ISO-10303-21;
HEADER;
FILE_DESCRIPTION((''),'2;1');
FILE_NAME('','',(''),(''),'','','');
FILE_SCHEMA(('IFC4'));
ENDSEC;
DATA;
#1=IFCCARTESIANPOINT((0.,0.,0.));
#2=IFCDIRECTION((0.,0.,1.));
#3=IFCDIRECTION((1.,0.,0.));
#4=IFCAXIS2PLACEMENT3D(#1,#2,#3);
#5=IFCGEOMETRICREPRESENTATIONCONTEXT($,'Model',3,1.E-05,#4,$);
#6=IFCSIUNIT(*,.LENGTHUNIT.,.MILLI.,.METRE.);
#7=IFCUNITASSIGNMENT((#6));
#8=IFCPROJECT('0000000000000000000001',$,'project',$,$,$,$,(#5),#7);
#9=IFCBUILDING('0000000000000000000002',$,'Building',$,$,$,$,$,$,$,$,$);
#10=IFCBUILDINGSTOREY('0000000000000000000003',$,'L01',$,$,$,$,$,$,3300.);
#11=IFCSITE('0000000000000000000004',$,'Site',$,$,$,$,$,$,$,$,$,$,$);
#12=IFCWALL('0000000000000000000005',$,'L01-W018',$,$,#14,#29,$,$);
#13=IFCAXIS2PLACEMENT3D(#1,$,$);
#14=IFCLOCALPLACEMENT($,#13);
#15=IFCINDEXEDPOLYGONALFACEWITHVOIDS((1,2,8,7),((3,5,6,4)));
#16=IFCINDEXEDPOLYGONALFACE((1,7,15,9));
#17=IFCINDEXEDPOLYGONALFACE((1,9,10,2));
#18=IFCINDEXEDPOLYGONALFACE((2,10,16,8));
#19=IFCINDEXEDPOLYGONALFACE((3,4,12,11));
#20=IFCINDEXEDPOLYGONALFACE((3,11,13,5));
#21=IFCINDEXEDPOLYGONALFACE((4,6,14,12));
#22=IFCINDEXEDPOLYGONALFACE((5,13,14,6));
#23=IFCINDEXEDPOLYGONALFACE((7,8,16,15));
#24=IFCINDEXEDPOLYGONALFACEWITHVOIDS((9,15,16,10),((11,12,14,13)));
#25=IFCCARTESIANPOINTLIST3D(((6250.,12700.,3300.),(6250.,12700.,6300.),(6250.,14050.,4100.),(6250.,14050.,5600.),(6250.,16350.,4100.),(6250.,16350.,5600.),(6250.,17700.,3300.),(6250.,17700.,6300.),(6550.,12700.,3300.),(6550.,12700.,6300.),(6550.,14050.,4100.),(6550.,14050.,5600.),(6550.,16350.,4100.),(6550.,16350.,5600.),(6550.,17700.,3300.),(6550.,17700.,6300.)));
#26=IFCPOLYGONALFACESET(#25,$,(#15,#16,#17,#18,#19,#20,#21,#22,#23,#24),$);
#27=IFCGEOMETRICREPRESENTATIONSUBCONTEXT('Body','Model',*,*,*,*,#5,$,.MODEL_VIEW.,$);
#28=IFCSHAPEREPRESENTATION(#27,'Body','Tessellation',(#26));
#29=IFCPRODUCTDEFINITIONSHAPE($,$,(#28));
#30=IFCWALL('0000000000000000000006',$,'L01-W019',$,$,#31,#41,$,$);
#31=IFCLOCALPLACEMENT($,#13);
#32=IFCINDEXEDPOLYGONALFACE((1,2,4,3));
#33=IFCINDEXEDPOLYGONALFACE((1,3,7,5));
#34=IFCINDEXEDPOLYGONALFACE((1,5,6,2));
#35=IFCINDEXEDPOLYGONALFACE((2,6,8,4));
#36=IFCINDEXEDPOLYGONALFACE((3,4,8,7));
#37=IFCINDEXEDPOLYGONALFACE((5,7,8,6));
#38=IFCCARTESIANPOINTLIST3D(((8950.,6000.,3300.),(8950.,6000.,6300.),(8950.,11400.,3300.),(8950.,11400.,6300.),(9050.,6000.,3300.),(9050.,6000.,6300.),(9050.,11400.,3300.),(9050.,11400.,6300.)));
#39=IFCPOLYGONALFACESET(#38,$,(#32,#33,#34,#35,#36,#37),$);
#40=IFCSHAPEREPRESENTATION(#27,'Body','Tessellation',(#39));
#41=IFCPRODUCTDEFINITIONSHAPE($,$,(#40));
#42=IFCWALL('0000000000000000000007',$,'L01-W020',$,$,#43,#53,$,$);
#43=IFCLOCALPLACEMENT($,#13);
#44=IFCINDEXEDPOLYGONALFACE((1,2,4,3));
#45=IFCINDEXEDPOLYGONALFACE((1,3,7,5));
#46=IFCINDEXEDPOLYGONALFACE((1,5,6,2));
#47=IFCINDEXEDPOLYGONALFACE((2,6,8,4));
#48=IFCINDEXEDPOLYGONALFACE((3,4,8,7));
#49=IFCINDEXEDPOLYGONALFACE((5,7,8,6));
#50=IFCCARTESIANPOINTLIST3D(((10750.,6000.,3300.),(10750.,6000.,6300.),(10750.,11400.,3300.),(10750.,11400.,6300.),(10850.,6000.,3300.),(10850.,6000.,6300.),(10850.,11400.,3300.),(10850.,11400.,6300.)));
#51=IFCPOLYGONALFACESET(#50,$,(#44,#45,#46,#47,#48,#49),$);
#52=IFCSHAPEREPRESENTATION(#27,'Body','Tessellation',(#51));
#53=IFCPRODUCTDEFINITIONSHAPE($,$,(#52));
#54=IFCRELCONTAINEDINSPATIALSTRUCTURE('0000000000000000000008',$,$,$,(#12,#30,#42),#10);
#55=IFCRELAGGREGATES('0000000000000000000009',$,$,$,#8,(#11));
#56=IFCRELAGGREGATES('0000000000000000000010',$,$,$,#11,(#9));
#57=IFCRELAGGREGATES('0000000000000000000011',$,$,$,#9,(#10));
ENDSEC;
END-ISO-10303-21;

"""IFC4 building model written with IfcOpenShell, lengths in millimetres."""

from ifc_helpers import new_model, si_unit, frame, origin_with_axes, place, context, subcontext, project, spatial, indexed_curve, outline, extrude, element, save


model = new_model("IFC4")

# Units and contexts
model_context = context("Model", 3, precision=1e-05, world=origin_with_axes())
body_context = subcontext(model_context, "Body", "Model", "MODEL_VIEW")
ifc_project = project(units=[si_unit("LENGTHUNIT", "METRE", prefix="MILLI")], contexts=[model_context])

# Site, building, storey
site = spatial("IfcSite", under=ifc_project, Name="Site")
building = spatial("IfcBuilding", under=site, Name="Building")
storey = spatial("IfcBuildingStorey", under=building, Name="L01", Elevation=3300.0)

# Wall, opening
wall_1_placement = place(None, frame((6550.0, 12700.0, 3300.0), z_axis=(0.0, 0.0, 1.0), x_axis=(0.0, 1.0, 0.0)))
wall_1 = element("IfcWall", 1, at=wall_1_placement, inside=storey, Name="L01-W018", context=body_context, shape_type="SweptSolid", body=[
    extrude(outline(indexed_curve([(0.0, 0.0), (0.0, 300.0), (5000.0, 300.0), (5000.0, 0.0), (0.0, 0.0)], self_intersect=False)), origin_with_axes(), (0.0, 0.0, 1.0), 3000.0),
])
opening_1_placement = place(wall_1_placement, frame((1350.0, -10.0, 800.0), z_axis=(0.0, 0.0, 1.0), x_axis=(1.0, 0.0, 0.0)))
element("IfcOpeningElement", 2, at=opening_1_placement, cuts=wall_1, context=body_context, shape_type="SweptSolid", body=[
    extrude(outline(indexed_curve([(0.0, 0.0), (0.0, 320.0), (2300.0, 320.0), (2300.0, 0.0), (0.0, 0.0)], self_intersect=False)), origin_with_axes(), (0.0, 0.0, 1.0), 1500.0),
])

# Walls
for number, where, z_axis, x_axis, name in (
    (3, (9050.0, 6000.0, 3300.0), (0.0, 0.0, 1.0), (0.0, 1.0, 0.0), "L01-W019"),
    (4, (10850.0, 6000.0, 3300.0), (0.0, 0.0, 1.0), (0.0, 1.0, 0.0), "L01-W020"),
):
    element("IfcWall", number, at=place(None, frame(where, z_axis=z_axis, x_axis=x_axis)), inside=storey, Name=name, context=body_context, shape_type="SweptSolid", body=[
        extrude(outline(indexed_curve([(0.0, 0.0), (0.0, 100.0), (5400.0, 100.0), (5400.0, 0.0), (0.0, 0.0)], self_intersect=False)), origin_with_axes(), (0.0, 0.0, 1.0), 3000.0),
    ])

save(model, "model.ifc")
